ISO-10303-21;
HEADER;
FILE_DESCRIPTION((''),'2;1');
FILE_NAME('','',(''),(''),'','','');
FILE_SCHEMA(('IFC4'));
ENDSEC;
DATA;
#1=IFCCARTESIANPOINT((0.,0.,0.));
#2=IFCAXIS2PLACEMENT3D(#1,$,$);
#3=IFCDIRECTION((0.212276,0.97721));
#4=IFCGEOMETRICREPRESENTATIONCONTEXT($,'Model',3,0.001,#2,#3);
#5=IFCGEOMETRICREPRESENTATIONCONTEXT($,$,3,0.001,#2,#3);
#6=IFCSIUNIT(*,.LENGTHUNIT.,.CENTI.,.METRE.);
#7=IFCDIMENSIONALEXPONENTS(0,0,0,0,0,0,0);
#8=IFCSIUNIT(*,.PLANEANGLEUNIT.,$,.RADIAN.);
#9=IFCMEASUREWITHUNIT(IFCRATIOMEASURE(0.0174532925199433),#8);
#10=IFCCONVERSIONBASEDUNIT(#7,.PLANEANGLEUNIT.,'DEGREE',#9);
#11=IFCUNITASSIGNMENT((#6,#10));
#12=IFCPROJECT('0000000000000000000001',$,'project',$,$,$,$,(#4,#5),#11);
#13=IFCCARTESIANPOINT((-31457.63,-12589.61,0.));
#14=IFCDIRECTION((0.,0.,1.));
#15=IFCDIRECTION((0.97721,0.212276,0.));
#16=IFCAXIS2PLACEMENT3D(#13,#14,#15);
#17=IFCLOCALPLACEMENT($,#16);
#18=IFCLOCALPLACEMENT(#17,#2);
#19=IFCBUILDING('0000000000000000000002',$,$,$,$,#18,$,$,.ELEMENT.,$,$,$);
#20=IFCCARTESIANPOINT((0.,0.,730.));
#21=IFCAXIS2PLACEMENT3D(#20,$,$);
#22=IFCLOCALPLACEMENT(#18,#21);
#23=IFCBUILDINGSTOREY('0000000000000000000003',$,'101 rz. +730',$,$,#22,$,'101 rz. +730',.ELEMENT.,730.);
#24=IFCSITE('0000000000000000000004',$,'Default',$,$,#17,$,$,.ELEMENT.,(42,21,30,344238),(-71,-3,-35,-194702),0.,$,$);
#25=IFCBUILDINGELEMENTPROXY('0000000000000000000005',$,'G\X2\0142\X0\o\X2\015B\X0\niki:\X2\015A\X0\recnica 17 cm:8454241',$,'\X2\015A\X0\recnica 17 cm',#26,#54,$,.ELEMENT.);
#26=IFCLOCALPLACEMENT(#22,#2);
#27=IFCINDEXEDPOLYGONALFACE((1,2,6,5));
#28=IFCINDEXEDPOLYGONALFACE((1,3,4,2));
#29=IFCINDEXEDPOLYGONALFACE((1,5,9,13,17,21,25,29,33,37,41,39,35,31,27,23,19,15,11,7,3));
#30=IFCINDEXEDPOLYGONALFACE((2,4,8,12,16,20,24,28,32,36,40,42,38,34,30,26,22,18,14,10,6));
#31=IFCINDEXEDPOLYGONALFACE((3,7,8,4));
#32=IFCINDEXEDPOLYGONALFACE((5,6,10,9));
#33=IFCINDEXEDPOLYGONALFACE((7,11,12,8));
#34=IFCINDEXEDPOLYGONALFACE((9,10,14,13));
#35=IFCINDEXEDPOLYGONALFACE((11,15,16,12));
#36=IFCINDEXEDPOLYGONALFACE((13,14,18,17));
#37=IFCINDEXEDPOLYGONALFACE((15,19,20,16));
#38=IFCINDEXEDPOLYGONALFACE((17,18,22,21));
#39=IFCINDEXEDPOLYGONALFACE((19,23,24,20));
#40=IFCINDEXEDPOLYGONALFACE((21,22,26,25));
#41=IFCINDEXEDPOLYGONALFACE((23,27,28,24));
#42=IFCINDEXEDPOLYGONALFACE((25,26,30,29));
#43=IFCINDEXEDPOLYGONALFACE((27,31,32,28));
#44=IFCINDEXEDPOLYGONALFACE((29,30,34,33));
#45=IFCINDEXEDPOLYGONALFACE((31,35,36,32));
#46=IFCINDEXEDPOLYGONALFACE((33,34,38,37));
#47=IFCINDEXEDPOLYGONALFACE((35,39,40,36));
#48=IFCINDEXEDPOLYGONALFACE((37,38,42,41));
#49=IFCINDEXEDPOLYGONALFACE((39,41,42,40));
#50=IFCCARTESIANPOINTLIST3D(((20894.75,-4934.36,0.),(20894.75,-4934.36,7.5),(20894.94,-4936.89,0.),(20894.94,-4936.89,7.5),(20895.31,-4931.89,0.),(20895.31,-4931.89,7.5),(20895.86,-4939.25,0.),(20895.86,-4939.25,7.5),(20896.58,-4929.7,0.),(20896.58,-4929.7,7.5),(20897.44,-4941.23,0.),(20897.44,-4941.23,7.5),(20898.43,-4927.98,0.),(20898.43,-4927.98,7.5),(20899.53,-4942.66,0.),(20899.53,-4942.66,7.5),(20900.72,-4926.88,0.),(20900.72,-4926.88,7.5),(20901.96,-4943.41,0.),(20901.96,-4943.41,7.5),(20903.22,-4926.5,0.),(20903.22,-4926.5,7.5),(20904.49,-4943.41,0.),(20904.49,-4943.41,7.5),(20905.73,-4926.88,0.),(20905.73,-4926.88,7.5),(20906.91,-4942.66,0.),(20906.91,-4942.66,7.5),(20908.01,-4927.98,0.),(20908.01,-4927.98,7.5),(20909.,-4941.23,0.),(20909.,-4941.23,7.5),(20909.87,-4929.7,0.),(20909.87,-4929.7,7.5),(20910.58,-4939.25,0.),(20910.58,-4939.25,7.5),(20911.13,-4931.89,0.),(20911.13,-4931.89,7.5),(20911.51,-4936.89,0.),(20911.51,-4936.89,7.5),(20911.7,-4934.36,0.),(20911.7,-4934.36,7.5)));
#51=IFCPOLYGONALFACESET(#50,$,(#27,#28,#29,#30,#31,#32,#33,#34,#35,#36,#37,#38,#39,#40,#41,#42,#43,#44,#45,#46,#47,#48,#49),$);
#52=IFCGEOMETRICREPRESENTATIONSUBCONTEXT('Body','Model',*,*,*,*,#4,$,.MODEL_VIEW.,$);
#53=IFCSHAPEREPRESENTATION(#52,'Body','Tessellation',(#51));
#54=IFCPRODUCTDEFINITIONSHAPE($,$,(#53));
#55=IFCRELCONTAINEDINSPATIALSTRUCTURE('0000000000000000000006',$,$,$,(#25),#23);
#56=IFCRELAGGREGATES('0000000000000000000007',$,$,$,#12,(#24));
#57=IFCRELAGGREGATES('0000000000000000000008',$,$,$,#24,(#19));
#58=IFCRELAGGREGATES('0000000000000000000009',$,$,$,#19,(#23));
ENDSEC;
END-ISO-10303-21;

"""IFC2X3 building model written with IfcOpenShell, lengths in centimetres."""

from ifc_helpers import new_model, entity, si_unit, converted_unit, direction, frame, frame_2d, origin, place, context, subcontext, project, spatial, circle, extrude, source, transform, mapped, element, save


model = new_model("IFC2X3")

# Units and contexts
model_context = context("Model", 3, precision=0.001, world=origin(), true_north=direction((0.212276, 0.97721)))
context_of_model = context(None, 3, precision=0.001, world=origin(), true_north=direction((0.212276, 0.97721)))
body_context = subcontext(model_context, "Body", "Model", "MODEL_VIEW")
ifc_project = project(units=[si_unit("LENGTHUNIT", "METRE", prefix="CENTI"), converted_unit("PLANEANGLEUNIT", "DEGREE", entity("IfcRatioMeasure", 0.0174532925199433), si_unit("PLANEANGLEUNIT", "RADIAN"), dimensions=[0, 0, 0, 0, 0, 0, 0])], contexts=[model_context, context_of_model])

# Site, building, storey
site_placement = place(None, frame((-31457.63, -12589.61, 0.0), z_axis=(0.0, 0.0, 1.0), x_axis=(0.97721, 0.212276, 0.0)))
site = spatial("IfcSite", under=ifc_project, at=site_placement, Name="Default", CompositionType="ELEMENT", RefLatitude=(42, 21, 30, 344238), RefLongitude=(-71, -3, -35, -194702), RefElevation=0.0)
building_placement = place(site_placement, origin())
building = spatial("IfcBuilding", under=site, at=building_placement, CompositionType="ELEMENT")
storey_placement = place(building_placement, frame((0.0, 0.0, 730.0)))
storey = spatial("IfcBuildingStorey", under=building, at=storey_placement, Name="101 rz. +730", LongName="101 rz. +730", CompositionType="ELEMENT", Elevation=730.0)

# Building element proxy
shared_shape_1 = source(origin(), body_context, "Body", "SweptSolid", [
    extrude(circle(Radius=8.5, at=frame_2d((0.0, 0.0), x_axis=(1.0, 0.0))), frame((0.0, 0.0, 0.0), z_axis=(0.0, 0.0, 1.0), x_axis=(0.0, 1.0, 0.0)), (0.0, 0.0, 1.0), 7.5),
])
for number, where, name in (
    (1, (20903.22, -4935.0, 0.0), "Głośniki:Śrecnica 17 cm:8454241"),
):
    element("IfcBuildingElementProxy", number, at=place(storey_placement, frame(where)), inside=storey, Name=name, ObjectType="Śrecnica 17 cm", CompositionType="ELEMENT", context=body_context, shape_type="MappedRepresentation", body=[
        mapped(shared_shape_1, transform((0.0, 0.0, 0.0), scale=1.0)),
    ])

save(model, "model.ifc")
